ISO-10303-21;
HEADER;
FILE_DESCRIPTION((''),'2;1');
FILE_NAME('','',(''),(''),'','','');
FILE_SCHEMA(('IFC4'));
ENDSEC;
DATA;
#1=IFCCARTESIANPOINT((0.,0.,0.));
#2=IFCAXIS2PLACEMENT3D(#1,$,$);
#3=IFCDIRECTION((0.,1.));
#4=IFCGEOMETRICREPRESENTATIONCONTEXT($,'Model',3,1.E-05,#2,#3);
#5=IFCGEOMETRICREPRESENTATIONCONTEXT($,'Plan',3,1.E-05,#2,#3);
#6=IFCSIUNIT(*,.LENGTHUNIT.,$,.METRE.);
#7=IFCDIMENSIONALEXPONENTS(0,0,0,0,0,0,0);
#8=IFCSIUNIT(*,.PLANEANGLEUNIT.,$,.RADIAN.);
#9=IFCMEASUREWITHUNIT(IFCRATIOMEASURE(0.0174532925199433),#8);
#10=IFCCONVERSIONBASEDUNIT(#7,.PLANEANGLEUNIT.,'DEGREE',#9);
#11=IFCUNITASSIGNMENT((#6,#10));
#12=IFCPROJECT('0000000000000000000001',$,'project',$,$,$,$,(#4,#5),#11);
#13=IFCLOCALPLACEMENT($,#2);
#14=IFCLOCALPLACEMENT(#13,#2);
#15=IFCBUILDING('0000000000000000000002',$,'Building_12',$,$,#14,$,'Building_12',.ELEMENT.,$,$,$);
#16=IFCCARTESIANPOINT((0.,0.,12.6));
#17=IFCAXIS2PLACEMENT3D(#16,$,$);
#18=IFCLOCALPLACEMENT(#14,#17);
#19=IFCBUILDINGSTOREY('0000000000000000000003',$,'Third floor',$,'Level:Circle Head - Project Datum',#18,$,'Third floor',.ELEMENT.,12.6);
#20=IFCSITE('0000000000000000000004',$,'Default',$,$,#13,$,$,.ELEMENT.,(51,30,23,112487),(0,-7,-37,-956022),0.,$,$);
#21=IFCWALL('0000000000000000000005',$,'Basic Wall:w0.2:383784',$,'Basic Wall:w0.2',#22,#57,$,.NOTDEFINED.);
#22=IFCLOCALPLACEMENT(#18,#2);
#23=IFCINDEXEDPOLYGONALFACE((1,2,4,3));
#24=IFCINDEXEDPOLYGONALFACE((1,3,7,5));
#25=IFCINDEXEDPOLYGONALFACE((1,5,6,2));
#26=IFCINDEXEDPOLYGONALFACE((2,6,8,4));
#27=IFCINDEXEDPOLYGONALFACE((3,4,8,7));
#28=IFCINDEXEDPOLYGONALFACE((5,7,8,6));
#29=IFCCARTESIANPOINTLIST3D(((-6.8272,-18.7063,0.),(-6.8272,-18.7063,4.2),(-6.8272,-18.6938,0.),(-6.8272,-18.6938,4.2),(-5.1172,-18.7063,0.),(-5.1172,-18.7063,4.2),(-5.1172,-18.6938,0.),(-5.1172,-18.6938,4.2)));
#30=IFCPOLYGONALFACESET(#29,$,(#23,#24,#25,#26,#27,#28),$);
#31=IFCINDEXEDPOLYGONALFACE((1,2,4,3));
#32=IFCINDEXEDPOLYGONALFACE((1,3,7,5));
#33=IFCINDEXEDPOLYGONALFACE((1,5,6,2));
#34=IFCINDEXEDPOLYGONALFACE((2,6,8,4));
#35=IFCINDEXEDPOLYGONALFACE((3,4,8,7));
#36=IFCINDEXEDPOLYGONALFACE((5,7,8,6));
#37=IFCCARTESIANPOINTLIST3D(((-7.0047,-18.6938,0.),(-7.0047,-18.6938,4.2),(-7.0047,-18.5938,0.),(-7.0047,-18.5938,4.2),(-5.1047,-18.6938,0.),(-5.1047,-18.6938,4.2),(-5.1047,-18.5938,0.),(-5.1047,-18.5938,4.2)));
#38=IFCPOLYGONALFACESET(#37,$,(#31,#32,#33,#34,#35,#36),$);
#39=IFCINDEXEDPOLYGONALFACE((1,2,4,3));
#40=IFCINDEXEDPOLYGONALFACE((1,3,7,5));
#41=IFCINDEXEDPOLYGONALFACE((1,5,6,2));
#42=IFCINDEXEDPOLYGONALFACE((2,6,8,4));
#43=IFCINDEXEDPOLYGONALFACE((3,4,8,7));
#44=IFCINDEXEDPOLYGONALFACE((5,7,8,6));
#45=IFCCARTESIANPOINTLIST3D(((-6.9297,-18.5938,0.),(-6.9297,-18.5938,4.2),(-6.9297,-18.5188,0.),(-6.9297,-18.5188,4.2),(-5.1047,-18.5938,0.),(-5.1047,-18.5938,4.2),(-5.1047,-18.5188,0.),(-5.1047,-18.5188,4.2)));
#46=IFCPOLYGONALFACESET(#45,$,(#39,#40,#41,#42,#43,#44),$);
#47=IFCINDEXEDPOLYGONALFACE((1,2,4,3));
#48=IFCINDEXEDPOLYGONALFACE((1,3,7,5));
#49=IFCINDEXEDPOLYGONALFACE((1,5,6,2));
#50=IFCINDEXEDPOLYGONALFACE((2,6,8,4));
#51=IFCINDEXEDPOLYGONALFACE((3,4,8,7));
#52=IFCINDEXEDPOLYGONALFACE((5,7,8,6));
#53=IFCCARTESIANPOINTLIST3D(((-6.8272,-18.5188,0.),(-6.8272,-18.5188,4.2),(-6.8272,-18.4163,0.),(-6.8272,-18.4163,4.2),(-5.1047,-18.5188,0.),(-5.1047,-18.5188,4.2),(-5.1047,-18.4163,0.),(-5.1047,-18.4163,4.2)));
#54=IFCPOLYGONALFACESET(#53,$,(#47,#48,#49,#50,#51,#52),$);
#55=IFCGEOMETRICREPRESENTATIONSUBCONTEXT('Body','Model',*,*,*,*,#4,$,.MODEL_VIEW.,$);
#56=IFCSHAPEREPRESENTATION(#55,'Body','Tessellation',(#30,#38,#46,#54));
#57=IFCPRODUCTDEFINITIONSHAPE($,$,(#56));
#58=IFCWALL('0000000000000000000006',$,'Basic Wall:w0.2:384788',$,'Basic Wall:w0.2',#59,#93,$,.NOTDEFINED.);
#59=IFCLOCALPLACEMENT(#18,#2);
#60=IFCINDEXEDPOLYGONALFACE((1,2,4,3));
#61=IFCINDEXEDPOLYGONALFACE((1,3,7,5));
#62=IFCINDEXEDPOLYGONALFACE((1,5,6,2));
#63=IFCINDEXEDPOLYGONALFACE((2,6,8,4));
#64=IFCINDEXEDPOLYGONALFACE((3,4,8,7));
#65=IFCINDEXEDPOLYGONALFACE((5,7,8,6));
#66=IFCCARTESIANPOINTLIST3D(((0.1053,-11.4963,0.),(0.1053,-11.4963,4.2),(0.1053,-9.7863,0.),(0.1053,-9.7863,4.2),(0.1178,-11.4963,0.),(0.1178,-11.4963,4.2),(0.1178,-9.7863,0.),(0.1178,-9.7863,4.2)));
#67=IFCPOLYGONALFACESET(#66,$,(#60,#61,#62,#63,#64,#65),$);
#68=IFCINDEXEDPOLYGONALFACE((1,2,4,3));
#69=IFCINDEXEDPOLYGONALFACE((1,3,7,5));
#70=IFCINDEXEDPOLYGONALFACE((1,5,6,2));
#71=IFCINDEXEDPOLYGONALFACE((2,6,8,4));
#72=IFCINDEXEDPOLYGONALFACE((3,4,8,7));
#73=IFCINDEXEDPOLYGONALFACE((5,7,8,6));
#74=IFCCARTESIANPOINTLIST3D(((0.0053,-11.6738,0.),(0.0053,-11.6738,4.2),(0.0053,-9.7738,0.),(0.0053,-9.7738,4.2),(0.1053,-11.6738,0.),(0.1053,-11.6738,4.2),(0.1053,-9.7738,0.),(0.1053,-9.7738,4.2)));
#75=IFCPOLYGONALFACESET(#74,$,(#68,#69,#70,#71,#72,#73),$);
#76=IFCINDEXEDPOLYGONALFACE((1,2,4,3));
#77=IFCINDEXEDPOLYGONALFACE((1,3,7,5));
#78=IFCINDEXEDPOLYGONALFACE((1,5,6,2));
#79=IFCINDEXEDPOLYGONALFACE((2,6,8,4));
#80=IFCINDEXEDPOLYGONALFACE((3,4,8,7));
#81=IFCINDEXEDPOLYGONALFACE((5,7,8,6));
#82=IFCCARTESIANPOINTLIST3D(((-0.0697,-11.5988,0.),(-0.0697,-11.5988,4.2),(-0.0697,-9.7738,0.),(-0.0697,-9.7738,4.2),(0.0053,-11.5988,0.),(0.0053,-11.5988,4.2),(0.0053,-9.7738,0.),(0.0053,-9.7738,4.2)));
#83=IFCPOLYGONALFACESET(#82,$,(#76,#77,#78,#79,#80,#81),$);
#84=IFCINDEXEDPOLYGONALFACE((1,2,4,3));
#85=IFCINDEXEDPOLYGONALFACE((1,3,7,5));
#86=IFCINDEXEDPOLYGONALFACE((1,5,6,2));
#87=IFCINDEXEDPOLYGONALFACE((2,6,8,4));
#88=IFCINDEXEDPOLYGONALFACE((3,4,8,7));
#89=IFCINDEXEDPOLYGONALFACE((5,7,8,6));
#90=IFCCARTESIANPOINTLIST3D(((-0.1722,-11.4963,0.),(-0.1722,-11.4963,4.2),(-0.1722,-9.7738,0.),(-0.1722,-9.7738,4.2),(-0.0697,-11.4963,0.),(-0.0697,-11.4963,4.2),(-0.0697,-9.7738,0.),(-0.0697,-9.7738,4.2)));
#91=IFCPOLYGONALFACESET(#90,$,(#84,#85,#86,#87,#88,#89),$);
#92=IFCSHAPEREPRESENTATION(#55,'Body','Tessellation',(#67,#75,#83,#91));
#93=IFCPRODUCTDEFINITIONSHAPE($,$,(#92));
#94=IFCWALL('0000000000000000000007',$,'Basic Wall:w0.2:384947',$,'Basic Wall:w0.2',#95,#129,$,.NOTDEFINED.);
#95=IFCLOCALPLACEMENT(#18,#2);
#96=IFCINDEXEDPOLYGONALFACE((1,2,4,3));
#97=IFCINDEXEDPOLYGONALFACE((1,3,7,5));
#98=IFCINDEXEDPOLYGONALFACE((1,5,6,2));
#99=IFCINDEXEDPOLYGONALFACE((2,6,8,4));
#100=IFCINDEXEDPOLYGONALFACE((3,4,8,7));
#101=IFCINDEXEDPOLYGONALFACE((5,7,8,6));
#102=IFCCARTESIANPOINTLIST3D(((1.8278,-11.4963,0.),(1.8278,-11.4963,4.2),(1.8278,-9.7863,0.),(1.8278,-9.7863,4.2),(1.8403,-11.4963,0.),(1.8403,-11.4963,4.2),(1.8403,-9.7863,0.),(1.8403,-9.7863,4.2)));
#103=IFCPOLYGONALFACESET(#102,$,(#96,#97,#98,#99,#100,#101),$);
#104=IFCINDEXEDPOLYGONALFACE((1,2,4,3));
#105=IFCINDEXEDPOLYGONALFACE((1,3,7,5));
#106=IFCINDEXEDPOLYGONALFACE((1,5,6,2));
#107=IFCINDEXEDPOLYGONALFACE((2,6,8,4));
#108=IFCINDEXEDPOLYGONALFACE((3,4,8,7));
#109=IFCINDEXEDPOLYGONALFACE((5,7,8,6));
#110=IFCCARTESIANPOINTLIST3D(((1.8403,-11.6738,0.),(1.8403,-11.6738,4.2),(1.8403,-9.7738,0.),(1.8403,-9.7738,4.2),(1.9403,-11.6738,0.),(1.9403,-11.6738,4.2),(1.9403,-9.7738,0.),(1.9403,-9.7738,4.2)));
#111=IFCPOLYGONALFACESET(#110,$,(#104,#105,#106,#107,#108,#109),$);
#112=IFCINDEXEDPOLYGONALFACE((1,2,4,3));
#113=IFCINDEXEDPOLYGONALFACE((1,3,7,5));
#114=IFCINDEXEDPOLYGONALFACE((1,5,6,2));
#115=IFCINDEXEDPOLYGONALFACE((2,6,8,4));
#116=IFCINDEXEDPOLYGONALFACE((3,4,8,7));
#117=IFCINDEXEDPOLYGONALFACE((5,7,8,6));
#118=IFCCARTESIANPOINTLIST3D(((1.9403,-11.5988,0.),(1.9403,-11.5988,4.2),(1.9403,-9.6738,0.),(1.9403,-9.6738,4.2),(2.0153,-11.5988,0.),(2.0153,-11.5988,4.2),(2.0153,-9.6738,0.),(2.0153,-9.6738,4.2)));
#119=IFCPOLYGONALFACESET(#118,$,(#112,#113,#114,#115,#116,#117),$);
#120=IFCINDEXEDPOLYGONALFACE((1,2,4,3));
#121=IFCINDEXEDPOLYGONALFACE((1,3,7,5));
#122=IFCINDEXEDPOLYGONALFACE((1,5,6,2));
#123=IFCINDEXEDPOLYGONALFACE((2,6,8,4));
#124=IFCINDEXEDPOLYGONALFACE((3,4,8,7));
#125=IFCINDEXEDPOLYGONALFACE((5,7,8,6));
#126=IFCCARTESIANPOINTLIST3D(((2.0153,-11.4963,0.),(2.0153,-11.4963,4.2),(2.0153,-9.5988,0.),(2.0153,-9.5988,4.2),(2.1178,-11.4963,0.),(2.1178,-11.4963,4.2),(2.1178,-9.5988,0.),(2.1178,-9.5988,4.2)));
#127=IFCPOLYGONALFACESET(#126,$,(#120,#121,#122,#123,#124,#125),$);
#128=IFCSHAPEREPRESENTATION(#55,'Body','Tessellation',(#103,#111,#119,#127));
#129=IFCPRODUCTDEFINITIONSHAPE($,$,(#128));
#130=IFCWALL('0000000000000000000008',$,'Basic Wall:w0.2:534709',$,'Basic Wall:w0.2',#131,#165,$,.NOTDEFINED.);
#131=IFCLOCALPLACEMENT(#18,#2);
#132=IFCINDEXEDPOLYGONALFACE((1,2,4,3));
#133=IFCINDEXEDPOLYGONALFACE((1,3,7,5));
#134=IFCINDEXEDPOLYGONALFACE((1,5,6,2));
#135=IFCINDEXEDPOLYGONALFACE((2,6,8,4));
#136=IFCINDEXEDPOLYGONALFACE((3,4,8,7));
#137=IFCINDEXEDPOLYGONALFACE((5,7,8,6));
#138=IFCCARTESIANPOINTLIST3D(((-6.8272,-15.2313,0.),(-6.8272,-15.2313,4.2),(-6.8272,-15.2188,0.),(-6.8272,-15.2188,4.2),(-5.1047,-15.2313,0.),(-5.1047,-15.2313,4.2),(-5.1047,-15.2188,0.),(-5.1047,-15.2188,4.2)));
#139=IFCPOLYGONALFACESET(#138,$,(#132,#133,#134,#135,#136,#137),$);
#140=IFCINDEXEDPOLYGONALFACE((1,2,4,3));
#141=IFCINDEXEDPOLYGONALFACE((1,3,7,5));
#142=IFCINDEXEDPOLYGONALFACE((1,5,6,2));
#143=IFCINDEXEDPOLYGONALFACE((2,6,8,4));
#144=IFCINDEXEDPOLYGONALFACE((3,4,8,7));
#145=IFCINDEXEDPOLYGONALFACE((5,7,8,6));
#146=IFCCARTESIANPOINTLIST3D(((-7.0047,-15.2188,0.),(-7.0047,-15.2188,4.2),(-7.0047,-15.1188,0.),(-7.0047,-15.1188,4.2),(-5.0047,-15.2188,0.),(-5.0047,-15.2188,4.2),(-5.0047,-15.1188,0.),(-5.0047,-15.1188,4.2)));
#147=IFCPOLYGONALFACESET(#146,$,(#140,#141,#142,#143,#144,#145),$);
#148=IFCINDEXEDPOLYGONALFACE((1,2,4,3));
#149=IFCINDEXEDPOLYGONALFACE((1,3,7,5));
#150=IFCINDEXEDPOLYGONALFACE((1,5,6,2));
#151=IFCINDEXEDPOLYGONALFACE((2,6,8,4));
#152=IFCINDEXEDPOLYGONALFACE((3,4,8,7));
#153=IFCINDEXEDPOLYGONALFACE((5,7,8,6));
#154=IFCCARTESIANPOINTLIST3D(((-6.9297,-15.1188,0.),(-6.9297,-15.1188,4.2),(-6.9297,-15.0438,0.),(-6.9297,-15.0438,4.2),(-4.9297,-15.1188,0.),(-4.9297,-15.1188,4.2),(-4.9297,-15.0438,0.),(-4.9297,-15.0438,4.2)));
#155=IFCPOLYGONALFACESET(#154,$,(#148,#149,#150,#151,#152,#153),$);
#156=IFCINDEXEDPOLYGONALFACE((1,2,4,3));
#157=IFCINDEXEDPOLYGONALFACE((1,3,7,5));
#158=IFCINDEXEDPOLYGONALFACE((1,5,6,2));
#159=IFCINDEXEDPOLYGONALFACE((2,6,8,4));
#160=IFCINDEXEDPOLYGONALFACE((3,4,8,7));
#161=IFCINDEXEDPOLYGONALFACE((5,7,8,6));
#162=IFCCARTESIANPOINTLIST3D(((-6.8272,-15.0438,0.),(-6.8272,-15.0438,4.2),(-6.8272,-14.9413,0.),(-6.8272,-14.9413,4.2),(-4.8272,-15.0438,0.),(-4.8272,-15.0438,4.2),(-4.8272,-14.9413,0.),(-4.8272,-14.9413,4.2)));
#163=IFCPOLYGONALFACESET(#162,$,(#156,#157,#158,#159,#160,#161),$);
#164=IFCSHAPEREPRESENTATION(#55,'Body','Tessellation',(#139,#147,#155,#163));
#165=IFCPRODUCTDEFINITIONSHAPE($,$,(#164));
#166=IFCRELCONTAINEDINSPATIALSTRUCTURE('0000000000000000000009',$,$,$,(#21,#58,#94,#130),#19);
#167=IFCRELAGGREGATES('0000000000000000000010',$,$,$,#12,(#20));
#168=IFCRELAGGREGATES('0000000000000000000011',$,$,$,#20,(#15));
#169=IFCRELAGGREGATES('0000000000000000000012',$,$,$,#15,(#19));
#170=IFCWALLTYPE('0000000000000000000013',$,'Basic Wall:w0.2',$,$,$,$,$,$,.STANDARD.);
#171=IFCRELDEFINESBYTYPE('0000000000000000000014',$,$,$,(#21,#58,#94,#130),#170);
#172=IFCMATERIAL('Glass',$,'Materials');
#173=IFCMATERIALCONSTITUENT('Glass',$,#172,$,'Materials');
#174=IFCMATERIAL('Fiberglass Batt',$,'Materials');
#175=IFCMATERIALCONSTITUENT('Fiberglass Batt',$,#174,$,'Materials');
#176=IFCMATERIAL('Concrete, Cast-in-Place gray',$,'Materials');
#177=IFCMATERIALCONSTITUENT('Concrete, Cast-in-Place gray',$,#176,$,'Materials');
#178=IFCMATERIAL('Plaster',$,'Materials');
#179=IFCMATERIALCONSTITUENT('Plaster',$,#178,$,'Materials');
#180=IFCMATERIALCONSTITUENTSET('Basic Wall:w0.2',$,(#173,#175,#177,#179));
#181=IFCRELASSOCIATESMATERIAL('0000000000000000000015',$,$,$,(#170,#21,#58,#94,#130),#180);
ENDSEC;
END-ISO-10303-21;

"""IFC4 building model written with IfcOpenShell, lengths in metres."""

from ifc_helpers import new_model, entity, si_unit, converted_unit, direction, frame, origin, place, context, subcontext, project, spatial, indexed_curve, outline, extrude, material, constituent, constituent_set, type_object, element, save


model = new_model("IFC4")

# Units and contexts
model_context = context("Model", 3, precision=1e-05, world=origin(), true_north=direction((0.0, 1.0)))
plan_context = context("Plan", 3, precision=1e-05, world=origin(), true_north=direction((0.0, 1.0)))
body_context = subcontext(model_context, "Body", "Model", "MODEL_VIEW")
ifc_project = project(units=[si_unit("LENGTHUNIT", "METRE"), converted_unit("PLANEANGLEUNIT", "DEGREE", entity("IfcRatioMeasure", 0.0174532925199433), si_unit("PLANEANGLEUNIT", "RADIAN"), dimensions=[0, 0, 0, 0, 0, 0, 0])], contexts=[model_context, plan_context])

# Site, building, storey
site_placement = place(None, origin())
site = spatial("IfcSite", under=ifc_project, at=site_placement, Name="Default", CompositionType="ELEMENT", RefLatitude=(51, 30, 23, 112487), RefLongitude=(0, -7, -37, -956022), RefElevation=0.0)
building_placement = place(site_placement, origin())
building = spatial("IfcBuilding", under=site, at=building_placement, Name="Building_12", LongName="Building_12", CompositionType="ELEMENT")
storey_placement = place(building_placement, frame((0.0, 0.0, 12.6)))
storey = spatial("IfcBuildingStorey", under=building, at=storey_placement, Name="Third floor", ObjectType="Level:Circle Head - Project Datum", LongName="Third floor", CompositionType="ELEMENT", Elevation=12.6)

# Shared definitions
ifc_material_1 = material(Name="Glass", Category="Materials")
ifc_constituent_1 = constituent(ifc_material_1, Name="Glass", Category="Materials")
ifc_material_2 = material(Name="Fiberglass Batt", Category="Materials")
ifc_constituent_2 = constituent(ifc_material_2, Name="Fiberglass Batt", Category="Materials")
ifc_material_3 = material(Name="Concrete, Cast-in-Place gray", Category="Materials")
ifc_constituent_3 = constituent(ifc_material_3, Name="Concrete, Cast-in-Place gray", Category="Materials")
ifc_material_4 = material(Name="Plaster", Category="Materials")
ifc_constituent_4 = constituent(ifc_material_4, Name="Plaster", Category="Materials")
ifc_constituent_set = constituent_set(constituents=[ifc_constituent_1, ifc_constituent_2, ifc_constituent_3, ifc_constituent_4], Name="Basic Wall:w0.2")
wall_type = type_object("IfcWallType", Name="Basic Wall:w0.2", PredefinedType="STANDARD", material=ifc_constituent_set)

# Wall
wall_1_placement = place(storey_placement, frame((-6.8272, -18.5613, 0.0)))
element("IfcWall", 1, at=wall_1_placement, inside=storey, type_object=wall_type, material=ifc_constituent_set, Name="Basic Wall:w0.2:383784", ObjectType="Basic Wall:w0.2", PredefinedType="NOTDEFINED", context=body_context, shape_type="SweptSolid", body=[
    extrude(outline(indexed_curve([(-0.0063, -0.855), (0.0062, -0.855), (0.0063, 0.855), (-0.0062, 0.855), (-0.0063, -0.855)], self_intersect=False)), frame((0.855, -0.1388, 0.0), z_axis=(0.0, 0.0, 1.0), x_axis=(0.0, 1.0, 0.0)), (0.0, 0.0, 1.0), 4.2),
    extrude(outline(indexed_curve([(-0.95, -0.05), (0.95, -0.05), (0.95, 0.05), (-0.95, 0.05), (-0.95, -0.05)], self_intersect=False)), frame((0.7725, -0.0825, 0.0)), (0.0, 0.0, 1.0), 4.2),
    extrude(outline(indexed_curve([(-0.9125, -0.0375), (0.9125, -0.0375), (0.9125, 0.0375), (-0.9125, 0.0375), (-0.9125, -0.0375)], self_intersect=False)), frame((0.81, 0.005, 0.0)), (0.0, 0.0, 1.0), 4.2),
    extrude(outline(indexed_curve([(-0.0513, -0.8612), (0.0512, -0.8612), (0.0513, 0.8612), (-0.0512, 0.8612), (-0.0513, -0.8612)], self_intersect=False)), frame((0.8612, 0.0937, 0.0), z_axis=(0.0, 0.0, 1.0), x_axis=(0.0, -1.0, 0.0)), (0.0, 0.0, 1.0), 4.2),
])

# Walls
wall_2_placement = place(storey_placement, frame((-0.0272, -11.4963, 0.0), z_axis=(0.0, 0.0, 1.0), x_axis=(0.0, 1.0, 0.0)))
element("IfcWall", 2, at=wall_2_placement, inside=storey, type_object=wall_type, material=ifc_constituent_set, Name="Basic Wall:w0.2:384788", ObjectType="Basic Wall:w0.2", PredefinedType="NOTDEFINED", context=body_context, shape_type="SweptSolid", body=[
    extrude(outline(indexed_curve([(-0.0063, -0.855), (0.0062, -0.855), (0.0063, 0.855), (-0.0062, 0.855), (-0.0063, -0.855)], self_intersect=False)), frame((0.855, -0.1388, 0.0), z_axis=(0.0, 0.0, 1.0), x_axis=(0.0, 1.0, 0.0)), (0.0, 0.0, 1.0), 4.2),
    extrude(outline(indexed_curve([(-0.95, -0.05), (0.95, -0.05), (0.95, 0.05), (-0.95, 0.05), (-0.95, -0.05)], self_intersect=False)), frame((0.7725, -0.0825, 0.0)), (0.0, 0.0, 1.0), 4.2),
    extrude(outline(indexed_curve([(-0.9125, -0.0375), (0.9125, -0.0375), (0.9125, 0.0375), (-0.9125, 0.0375), (-0.9125, -0.0375)], self_intersect=False)), frame((0.81, 0.005, 0.0)), (0.0, 0.0, 1.0), 4.2),
    extrude(outline(indexed_curve([(-0.0513, -0.8613), (0.0512, -0.8613), (0.0513, 0.8612), (-0.0512, 0.8612), (-0.0513, -0.8613)], self_intersect=False)), frame((0.8613, 0.0937, 0.0), z_axis=(0.0, 0.0, 1.0), x_axis=(0.0, -1.0, 0.0)), (0.0, 0.0, 1.0), 4.2),
])
wall_3_placement = place(storey_placement, frame((1.9728, -9.7863, 0.0), z_axis=(0.0, 0.0, 1.0), x_axis=(0.0, -1.0, 0.0)))
element("IfcWall", 3, at=wall_3_placement, inside=storey, type_object=wall_type, material=ifc_constituent_set, Name="Basic Wall:w0.2:384947", ObjectType="Basic Wall:w0.2", PredefinedType="NOTDEFINED", context=body_context, shape_type="SweptSolid", body=[
    extrude(outline(indexed_curve([(-0.0063, -0.855), (0.0062, -0.855), (0.0063, 0.855), (-0.0062, 0.855), (-0.0063, -0.855)], self_intersect=False)), frame((0.855, -0.1388, 0.0), z_axis=(0.0, 0.0, 1.0), x_axis=(0.0, 1.0, 0.0)), (0.0, 0.0, 1.0), 4.2),
    extrude(outline(indexed_curve([(-0.95, -0.05), (0.95, -0.05), (0.95, 0.05), (-0.95, 0.05), (-0.95, -0.05)], self_intersect=False)), frame((0.9375, -0.0825, 0.0)), (0.0, 0.0, 1.0), 4.2),
    extrude(outline(indexed_curve([(-0.9625, -0.0375), (0.9625, -0.0375), (0.9625, 0.0375), (-0.9625, 0.0375), (-0.9625, -0.0375)], self_intersect=False)), frame((0.85, 0.005, 0.0)), (0.0, 0.0, 1.0), 4.2),
    extrude(outline(indexed_curve([(-0.0513, -0.9488), (0.0512, -0.9488), (0.0513, 0.9488), (-0.0512, 0.9488), (-0.0513, -0.9488)], self_intersect=False)), frame((0.7613, 0.0937, 0.0), z_axis=(0.0, 0.0, 1.0), x_axis=(0.0, -1.0, 0.0)), (0.0, 0.0, 1.0), 4.2),
])

# Wall, opening
wall_4_placement = place(storey_placement, frame((-6.8272, -15.0863, 0.0)))
wall_4 = element("IfcWall", 4, at=wall_4_placement, inside=storey, type_object=wall_type, material=ifc_constituent_set, Name="Basic Wall:w0.2:534709", ObjectType="Basic Wall:w0.2", PredefinedType="NOTDEFINED", context=body_context, shape_type="SweptSolid", body=[
    extrude(outline(indexed_curve([(-0.0063, -0.8613), (0.0062, -0.8613), (0.0063, 0.8612), (-0.0062, 0.8612), (-0.0063, -0.8613)], self_intersect=False)), frame((0.8613, -0.1388, 0.0), z_axis=(0.0, 0.0, 1.0), x_axis=(0.0, 1.0, 0.0)), (0.0, 0.0, 1.0), 4.2),
    extrude(outline(indexed_curve([(-1.0, -0.05), (1.0, -0.05), (1.0, 0.05), (-1.0, 0.05), (-1.0, -0.05)], self_intersect=False)), frame((0.8225, -0.0825, 0.0)), (0.0, 0.0, 1.0), 4.2),
    extrude(outline(indexed_curve([(-1.0, -0.0375), (1.0, -0.0375), (1.0, 0.0375), (-1.0, 0.0375), (-1.0, -0.0375)], self_intersect=False)), frame((0.8975, 0.005, 0.0)), (0.0, 0.0, 1.0), 4.2),
    extrude(outline(indexed_curve([(-0.0513, -1.0), (0.0512, -1.0), (0.0513, 1.0), (-0.0512, 1.0), (-0.0513, -1.0)], self_intersect=False)), frame((1.0, 0.0937, 0.0), z_axis=(0.0, 0.0, 1.0), x_axis=(0.0, -1.0, 0.0)), (0.0, 0.0, 1.0), 4.2),
])
opening_1_placement = place(wall_4_placement, origin())
element("IfcOpeningElement", 5, at=opening_1_placement, cuts=wall_4, PredefinedType="OPENING", context=body_context, shape_type="SweptSolid", body=[
    extrude(outline(indexed_curve([(-0.145, -1.055), (0.145, -1.055), (0.145, 1.055), (-0.145, 1.055), (-0.145, -1.055)], self_intersect=False)), frame((1.855, -1.055, 1.055), z_axis=(0.0, 1.0, 0.0), x_axis=(-1.0, 0.0, 0.0)), (0.0, 0.0, 1.0), 0.91),
])

save(model, "model.ifc")
